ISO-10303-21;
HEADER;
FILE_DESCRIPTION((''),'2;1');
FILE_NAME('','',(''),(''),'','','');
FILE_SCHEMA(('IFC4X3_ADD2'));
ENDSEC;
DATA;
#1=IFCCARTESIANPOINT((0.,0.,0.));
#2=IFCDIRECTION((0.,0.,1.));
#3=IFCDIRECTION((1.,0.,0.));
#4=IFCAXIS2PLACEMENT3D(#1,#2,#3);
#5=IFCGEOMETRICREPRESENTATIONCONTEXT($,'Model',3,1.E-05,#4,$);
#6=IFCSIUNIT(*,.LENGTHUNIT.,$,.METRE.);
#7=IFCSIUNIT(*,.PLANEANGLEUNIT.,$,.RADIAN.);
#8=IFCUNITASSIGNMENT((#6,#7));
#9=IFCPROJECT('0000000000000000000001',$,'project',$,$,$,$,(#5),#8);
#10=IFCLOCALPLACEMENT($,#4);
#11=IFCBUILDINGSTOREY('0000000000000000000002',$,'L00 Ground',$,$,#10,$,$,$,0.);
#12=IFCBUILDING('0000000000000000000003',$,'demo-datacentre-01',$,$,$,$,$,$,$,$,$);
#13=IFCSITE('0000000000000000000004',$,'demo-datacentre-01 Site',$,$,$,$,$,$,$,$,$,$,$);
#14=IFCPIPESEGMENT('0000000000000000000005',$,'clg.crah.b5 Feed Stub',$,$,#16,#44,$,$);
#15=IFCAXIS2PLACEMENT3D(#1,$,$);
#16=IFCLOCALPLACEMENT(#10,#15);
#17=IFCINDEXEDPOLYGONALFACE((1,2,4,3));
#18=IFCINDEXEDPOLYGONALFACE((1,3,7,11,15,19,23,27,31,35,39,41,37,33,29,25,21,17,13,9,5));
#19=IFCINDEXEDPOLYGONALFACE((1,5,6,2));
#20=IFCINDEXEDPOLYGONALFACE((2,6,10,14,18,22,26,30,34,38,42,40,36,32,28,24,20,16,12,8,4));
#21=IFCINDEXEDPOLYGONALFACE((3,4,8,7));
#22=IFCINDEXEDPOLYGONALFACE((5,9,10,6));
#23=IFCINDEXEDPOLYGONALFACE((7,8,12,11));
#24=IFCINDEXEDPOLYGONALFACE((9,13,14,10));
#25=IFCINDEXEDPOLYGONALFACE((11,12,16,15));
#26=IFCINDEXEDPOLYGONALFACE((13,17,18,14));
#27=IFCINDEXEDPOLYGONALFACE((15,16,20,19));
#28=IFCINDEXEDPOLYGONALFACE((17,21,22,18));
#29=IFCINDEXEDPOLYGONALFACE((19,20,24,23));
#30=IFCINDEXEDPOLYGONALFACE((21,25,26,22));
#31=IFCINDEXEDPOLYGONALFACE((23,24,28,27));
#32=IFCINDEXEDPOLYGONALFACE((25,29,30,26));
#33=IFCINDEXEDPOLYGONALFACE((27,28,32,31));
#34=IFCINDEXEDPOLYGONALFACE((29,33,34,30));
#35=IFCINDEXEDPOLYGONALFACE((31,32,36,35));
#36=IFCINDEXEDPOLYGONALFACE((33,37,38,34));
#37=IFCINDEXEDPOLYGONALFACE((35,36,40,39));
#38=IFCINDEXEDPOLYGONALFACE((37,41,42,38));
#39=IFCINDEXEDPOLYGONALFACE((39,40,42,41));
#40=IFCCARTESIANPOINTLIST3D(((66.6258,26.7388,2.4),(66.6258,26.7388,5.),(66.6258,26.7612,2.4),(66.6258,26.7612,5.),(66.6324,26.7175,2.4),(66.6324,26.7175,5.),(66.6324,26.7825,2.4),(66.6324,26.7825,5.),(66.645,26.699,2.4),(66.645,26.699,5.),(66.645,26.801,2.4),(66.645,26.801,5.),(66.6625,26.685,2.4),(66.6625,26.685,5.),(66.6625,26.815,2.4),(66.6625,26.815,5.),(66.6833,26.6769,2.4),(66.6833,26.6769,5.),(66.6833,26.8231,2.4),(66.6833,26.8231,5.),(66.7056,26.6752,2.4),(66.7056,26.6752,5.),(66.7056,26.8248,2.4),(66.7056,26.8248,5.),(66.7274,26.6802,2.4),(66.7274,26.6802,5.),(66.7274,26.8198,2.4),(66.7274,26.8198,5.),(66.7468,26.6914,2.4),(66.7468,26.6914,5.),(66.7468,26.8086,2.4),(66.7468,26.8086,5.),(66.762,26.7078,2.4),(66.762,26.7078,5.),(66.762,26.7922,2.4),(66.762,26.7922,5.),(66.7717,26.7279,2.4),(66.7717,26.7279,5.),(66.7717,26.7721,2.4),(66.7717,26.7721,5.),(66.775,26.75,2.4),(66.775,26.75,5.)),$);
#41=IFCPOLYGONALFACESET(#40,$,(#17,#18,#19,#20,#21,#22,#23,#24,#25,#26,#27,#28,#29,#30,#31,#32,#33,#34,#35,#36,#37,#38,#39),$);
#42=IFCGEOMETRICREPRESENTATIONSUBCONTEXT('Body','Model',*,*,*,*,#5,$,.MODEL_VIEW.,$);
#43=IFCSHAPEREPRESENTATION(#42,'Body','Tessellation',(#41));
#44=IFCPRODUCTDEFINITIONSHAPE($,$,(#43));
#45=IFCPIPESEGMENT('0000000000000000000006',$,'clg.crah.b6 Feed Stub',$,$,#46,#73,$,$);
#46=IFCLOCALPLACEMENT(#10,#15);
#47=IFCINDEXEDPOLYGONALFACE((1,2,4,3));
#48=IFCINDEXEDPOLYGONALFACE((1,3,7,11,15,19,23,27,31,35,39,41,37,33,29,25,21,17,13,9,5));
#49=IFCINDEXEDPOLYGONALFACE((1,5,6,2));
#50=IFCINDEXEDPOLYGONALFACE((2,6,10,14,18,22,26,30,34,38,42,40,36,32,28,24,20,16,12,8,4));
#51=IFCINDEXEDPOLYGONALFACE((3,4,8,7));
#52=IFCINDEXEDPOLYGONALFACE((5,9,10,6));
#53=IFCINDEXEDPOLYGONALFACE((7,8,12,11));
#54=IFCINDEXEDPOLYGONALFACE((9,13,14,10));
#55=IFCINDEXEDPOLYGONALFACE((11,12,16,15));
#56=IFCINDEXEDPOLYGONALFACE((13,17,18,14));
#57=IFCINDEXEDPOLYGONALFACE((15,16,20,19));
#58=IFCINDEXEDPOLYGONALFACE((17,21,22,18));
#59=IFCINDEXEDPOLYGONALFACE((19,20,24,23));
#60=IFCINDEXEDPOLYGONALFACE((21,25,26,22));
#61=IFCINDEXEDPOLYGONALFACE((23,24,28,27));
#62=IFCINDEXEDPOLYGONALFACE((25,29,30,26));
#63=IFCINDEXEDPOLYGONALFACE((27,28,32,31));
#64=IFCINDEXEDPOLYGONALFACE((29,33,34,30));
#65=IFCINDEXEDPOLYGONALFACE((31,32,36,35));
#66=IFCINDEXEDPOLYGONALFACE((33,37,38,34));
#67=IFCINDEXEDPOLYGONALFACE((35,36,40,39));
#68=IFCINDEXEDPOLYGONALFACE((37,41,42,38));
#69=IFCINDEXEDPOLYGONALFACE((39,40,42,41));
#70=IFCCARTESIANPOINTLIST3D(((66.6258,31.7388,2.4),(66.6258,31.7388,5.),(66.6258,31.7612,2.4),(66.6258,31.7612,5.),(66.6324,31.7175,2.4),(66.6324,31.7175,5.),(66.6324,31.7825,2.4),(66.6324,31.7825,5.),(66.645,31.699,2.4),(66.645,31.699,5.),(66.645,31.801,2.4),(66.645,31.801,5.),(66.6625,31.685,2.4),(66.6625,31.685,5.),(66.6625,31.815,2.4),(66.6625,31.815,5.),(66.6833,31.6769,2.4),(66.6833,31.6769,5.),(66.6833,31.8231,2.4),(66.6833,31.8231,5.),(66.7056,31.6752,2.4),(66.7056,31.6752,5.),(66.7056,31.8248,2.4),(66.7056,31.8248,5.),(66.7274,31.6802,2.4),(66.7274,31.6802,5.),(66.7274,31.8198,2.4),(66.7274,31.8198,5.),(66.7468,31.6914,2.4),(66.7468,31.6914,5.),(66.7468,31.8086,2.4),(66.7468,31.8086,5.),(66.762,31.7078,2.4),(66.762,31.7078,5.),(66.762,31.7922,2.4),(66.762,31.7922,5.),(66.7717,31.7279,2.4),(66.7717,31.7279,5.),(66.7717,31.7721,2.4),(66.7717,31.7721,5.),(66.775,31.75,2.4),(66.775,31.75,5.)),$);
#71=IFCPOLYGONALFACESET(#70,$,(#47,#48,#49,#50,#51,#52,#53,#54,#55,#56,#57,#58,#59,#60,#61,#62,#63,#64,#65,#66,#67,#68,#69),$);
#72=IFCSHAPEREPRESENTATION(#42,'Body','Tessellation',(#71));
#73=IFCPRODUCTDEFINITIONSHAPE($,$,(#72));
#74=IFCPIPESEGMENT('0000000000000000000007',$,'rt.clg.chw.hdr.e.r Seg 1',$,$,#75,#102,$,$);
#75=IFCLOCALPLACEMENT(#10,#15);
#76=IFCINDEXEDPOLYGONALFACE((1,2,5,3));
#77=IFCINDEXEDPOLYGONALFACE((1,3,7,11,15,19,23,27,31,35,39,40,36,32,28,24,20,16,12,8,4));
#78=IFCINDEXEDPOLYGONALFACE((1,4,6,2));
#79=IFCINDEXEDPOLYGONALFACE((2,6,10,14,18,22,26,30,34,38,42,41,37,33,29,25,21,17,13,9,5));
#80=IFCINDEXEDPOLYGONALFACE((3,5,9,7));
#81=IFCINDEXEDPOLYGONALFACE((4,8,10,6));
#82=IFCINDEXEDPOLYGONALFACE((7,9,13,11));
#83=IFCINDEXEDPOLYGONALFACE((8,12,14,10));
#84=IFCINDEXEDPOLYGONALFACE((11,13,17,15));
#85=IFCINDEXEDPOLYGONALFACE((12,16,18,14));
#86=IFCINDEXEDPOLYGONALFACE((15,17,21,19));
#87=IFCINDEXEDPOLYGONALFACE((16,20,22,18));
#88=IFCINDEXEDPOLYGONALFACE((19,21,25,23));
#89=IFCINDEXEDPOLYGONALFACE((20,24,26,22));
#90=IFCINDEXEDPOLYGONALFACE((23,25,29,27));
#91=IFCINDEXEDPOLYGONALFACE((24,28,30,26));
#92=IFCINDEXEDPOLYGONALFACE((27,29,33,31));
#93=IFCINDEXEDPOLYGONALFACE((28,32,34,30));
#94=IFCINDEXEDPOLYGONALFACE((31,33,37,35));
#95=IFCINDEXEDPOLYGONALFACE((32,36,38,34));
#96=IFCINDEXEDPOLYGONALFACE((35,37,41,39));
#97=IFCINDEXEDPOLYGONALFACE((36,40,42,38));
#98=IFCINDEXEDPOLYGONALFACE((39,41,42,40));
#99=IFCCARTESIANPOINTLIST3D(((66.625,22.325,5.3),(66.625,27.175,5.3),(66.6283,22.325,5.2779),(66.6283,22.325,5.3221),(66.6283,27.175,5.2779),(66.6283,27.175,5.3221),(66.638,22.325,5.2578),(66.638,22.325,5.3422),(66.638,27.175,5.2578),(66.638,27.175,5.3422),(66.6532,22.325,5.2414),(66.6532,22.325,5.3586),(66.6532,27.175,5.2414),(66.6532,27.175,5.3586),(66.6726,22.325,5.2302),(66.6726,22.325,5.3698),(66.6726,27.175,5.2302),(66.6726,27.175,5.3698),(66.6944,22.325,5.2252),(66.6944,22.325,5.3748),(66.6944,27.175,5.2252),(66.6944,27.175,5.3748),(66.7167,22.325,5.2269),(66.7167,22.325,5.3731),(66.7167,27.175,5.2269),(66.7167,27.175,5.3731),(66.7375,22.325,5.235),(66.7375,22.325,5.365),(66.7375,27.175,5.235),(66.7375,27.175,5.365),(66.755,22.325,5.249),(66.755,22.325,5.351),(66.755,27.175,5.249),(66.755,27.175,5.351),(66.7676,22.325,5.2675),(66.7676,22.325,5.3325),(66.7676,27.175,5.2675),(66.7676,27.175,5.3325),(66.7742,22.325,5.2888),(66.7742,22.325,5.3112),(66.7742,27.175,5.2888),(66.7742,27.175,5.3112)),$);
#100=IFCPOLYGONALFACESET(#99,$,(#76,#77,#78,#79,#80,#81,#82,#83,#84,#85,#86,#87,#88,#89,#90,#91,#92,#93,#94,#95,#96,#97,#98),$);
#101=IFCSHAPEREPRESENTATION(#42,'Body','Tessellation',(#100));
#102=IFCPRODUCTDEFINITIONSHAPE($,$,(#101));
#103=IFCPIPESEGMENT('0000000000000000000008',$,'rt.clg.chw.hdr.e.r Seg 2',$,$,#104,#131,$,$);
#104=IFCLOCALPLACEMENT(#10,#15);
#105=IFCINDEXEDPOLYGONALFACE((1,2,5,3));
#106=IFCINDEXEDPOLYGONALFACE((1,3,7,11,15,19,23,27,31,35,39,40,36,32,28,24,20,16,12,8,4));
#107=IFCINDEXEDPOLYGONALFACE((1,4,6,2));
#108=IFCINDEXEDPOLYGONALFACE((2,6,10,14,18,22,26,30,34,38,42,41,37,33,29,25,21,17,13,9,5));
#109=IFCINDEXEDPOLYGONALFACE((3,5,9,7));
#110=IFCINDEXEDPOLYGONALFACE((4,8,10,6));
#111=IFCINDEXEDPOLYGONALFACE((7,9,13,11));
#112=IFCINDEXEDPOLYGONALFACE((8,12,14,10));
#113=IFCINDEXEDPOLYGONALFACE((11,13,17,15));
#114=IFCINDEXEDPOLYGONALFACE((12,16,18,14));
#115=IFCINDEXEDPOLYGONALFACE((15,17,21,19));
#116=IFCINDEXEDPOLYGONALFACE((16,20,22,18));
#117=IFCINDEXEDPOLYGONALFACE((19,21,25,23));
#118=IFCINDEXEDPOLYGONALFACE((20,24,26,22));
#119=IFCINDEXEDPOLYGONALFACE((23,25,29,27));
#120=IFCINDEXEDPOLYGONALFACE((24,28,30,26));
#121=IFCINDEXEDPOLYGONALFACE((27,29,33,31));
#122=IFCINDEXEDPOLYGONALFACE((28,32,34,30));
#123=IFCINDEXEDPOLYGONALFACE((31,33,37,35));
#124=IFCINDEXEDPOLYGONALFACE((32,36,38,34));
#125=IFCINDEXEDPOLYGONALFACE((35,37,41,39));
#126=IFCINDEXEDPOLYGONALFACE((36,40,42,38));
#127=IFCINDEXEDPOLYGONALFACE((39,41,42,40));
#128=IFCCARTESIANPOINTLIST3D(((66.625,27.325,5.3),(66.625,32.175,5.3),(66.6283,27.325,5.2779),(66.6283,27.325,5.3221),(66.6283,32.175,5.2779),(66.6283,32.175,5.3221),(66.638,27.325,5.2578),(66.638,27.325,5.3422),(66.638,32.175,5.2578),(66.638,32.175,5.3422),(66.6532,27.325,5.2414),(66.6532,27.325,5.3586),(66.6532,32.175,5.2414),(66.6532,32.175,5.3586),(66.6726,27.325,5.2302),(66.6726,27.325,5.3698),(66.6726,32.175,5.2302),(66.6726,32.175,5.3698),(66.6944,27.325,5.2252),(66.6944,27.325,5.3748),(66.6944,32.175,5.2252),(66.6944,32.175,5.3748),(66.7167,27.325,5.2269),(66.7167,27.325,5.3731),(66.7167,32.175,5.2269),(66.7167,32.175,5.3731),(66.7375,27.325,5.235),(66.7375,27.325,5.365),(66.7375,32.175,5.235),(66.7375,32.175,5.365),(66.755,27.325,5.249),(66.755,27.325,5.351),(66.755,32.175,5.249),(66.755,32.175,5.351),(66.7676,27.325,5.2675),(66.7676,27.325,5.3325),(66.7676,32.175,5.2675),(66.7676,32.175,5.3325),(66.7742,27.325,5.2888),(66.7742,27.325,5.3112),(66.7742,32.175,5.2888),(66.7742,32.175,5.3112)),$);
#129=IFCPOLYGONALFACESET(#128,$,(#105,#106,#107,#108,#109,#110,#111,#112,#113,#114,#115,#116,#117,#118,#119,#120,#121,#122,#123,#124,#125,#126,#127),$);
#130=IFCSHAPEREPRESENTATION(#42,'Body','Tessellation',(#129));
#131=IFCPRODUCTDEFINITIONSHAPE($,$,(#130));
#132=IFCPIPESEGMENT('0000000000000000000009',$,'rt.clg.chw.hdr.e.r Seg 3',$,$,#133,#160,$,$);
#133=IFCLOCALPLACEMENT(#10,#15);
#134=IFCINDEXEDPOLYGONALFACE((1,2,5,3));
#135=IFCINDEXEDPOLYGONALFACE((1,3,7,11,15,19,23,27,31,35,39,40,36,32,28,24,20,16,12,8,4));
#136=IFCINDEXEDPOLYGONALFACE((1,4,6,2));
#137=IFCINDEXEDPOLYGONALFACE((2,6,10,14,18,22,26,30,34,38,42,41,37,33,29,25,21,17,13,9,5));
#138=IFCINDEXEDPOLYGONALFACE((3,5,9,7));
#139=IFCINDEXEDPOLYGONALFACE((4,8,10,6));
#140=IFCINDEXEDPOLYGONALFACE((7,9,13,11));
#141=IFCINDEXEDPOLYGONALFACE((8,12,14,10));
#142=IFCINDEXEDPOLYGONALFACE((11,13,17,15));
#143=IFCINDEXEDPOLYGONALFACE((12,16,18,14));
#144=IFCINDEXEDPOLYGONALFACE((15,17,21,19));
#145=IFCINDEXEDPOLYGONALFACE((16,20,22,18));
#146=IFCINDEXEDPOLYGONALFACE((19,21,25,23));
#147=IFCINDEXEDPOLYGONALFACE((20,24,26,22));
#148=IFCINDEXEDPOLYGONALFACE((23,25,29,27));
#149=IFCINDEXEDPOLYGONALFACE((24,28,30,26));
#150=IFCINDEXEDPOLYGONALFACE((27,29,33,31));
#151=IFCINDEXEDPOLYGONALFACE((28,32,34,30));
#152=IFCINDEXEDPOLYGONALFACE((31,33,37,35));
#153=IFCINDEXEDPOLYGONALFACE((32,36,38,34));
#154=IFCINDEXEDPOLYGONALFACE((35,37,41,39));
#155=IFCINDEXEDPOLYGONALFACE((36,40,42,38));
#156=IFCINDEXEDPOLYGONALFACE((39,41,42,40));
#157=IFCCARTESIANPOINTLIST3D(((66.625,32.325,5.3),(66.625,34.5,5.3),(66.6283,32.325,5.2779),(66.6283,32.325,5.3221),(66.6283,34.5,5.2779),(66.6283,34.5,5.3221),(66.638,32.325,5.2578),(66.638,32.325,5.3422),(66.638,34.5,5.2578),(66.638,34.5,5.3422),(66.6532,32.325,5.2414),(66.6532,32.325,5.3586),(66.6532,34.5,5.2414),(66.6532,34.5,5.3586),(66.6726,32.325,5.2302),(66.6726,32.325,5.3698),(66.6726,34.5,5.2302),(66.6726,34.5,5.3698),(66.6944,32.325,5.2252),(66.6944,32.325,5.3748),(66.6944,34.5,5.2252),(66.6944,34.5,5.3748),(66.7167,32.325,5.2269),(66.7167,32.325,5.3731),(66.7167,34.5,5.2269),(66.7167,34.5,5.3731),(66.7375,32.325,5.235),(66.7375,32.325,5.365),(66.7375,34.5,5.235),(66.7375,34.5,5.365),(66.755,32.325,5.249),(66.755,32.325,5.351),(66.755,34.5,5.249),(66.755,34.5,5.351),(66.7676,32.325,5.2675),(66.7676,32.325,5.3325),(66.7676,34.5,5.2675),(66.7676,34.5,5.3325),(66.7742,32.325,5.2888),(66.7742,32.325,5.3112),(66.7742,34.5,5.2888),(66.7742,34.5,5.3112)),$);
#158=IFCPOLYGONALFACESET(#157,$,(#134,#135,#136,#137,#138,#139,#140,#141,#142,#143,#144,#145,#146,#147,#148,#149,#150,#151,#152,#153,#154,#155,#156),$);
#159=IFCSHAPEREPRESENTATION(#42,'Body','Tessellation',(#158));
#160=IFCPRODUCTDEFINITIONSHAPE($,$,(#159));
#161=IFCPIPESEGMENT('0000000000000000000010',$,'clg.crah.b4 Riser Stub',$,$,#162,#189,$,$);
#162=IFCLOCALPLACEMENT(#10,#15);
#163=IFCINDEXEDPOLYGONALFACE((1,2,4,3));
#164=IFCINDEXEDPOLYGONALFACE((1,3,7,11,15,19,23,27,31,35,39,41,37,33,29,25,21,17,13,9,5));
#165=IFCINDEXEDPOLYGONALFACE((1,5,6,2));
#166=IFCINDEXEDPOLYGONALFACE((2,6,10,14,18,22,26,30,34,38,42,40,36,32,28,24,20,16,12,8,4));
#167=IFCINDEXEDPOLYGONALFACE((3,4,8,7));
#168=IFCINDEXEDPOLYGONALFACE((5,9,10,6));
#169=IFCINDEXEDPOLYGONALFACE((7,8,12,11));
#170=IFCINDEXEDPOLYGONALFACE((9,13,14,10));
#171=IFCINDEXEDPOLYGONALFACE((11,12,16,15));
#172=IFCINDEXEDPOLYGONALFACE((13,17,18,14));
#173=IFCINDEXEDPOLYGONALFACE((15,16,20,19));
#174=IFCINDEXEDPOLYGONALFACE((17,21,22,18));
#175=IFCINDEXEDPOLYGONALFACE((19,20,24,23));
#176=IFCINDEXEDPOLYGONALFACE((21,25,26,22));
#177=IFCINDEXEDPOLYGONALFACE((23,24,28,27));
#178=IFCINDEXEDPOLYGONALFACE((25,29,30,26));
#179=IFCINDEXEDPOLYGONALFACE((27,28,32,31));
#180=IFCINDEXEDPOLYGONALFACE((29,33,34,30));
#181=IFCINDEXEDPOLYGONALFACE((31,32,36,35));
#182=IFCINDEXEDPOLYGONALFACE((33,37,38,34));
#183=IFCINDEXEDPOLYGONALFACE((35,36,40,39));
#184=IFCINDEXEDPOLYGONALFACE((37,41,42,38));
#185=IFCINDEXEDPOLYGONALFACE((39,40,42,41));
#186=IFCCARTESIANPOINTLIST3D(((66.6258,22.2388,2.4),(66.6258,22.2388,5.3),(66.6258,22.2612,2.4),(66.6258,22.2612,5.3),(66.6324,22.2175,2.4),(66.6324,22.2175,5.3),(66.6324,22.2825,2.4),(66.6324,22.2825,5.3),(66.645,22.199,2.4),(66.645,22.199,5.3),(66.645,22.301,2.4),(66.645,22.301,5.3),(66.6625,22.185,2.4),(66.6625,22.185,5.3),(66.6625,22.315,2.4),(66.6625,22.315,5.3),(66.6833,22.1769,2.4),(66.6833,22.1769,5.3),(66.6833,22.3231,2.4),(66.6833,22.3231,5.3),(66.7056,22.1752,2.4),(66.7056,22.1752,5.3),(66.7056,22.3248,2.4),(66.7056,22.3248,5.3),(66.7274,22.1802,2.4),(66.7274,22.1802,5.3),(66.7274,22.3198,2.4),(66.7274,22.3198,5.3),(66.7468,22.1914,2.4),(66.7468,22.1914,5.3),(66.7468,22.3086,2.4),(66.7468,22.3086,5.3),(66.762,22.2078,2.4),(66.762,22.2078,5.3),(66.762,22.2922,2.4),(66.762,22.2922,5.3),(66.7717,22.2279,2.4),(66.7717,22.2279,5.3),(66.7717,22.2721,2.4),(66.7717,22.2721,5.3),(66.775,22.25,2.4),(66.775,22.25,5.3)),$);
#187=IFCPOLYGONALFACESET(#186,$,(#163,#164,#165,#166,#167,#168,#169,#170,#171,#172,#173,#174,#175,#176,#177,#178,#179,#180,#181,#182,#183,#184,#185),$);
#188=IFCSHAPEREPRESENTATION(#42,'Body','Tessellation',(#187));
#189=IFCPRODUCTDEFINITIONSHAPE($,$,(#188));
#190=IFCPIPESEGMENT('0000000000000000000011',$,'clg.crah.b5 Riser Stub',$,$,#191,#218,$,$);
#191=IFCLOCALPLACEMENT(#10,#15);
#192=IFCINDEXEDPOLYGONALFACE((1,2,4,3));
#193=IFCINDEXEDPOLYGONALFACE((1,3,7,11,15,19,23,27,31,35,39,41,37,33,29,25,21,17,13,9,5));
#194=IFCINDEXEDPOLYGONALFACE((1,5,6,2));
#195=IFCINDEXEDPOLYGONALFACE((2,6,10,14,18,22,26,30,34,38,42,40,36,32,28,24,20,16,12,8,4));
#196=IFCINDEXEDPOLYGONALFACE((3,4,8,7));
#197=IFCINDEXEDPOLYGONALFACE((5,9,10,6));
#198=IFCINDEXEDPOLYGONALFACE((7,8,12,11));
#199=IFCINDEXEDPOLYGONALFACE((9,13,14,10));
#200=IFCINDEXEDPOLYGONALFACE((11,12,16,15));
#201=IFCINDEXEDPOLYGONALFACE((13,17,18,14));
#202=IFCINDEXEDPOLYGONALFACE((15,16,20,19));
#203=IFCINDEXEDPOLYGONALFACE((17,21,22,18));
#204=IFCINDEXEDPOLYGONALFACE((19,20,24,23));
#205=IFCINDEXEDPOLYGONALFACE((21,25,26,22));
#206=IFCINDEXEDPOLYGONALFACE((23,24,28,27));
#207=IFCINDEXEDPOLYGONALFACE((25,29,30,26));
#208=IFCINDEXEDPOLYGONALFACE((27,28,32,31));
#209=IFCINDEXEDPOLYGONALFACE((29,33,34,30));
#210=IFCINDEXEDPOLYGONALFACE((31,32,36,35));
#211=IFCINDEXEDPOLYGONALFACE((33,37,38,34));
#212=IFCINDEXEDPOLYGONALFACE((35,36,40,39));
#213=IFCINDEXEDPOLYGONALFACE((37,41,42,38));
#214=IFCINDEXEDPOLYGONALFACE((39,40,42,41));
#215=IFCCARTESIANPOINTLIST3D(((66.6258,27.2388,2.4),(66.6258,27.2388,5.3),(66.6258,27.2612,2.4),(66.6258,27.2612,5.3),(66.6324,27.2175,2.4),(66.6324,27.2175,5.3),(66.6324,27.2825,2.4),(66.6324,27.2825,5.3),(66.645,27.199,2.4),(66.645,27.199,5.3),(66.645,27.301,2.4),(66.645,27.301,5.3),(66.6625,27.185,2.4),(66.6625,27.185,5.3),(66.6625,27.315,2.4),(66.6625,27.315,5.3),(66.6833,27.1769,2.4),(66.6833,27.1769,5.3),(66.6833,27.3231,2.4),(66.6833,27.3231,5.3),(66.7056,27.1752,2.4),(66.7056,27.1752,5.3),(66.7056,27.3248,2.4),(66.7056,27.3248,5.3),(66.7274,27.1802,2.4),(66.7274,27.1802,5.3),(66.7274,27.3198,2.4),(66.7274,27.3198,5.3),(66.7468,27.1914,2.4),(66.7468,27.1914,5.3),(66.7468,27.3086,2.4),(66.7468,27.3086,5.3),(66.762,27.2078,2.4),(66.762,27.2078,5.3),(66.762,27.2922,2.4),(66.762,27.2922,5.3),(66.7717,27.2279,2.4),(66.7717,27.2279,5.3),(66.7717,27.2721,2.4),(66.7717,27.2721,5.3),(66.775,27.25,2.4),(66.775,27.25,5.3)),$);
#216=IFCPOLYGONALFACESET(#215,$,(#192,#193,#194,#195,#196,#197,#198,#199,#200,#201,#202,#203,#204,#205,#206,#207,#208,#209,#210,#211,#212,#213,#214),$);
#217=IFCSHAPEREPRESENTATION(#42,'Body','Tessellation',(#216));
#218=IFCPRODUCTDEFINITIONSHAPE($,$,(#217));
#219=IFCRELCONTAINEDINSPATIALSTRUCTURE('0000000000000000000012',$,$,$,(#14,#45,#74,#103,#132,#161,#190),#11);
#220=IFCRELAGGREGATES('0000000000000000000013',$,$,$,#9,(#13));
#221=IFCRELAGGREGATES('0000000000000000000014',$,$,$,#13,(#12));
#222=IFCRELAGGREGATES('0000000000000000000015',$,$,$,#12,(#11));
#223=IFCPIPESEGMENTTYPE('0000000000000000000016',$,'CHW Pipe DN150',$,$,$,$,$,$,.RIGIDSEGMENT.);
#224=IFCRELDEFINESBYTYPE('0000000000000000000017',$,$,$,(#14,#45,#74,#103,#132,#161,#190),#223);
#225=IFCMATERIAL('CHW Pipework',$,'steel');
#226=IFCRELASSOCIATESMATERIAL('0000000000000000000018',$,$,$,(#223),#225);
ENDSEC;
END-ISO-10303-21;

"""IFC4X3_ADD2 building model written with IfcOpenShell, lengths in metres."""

from ifc_helpers import new_model, si_unit, frame, origin_with_axes, place, context, subcontext, project, spatial, circle, extrude, material, type_object, element, save


model = new_model("IFC4X3_ADD2")

# Units and contexts
model_context = context("Model", 3, precision=1e-05, world=origin_with_axes())
body_context = subcontext(model_context, "Body", "Model", "MODEL_VIEW")
ifc_project = project(units=[si_unit("LENGTHUNIT", "METRE"), si_unit("PLANEANGLEUNIT", "RADIAN")], contexts=[model_context])

# Site, building, storey
site = spatial("IfcSite", under=ifc_project, Name="demo-datacentre-01 Site")
building = spatial("IfcBuilding", under=site, Name="demo-datacentre-01")
storey_placement = place(None, origin_with_axes())
storey = spatial("IfcBuildingStorey", under=building, at=storey_placement, Name="L00 Ground", Elevation=0.0)

# Shared definitions
ifc_material = material(Name="CHW Pipework", Category="steel")

# Pipe segments
pipe_segment_type_1 = type_object("IfcPipeSegmentType", Name="CHW Pipe DN150", PredefinedType="RIGIDSEGMENT", material=ifc_material)
for number, where, z_axis, x_axis, name in (
    (1, (66.7, 26.75, 5.0), (0.0, 0.0, -1.0), (1.0, 0.0, 0.0), "clg.crah.b5 Feed Stub"),
    (2, (66.7, 31.75, 5.0), (0.0, 0.0, -1.0), (1.0, 0.0, 0.0), "clg.crah.b6 Feed Stub"),
):
    element("IfcPipeSegment", number, at=place(storey_placement, frame(where, z_axis=z_axis, x_axis=x_axis)), inside=storey, type_object=pipe_segment_type_1, Name=name, context=body_context, shape_type="SweptSolid", body=[
        extrude(circle(Radius=0.075), origin_with_axes(), (0.0, 0.0, 1.0), 2.6),
    ])
pipe_segment_1_placement = place(storey_placement, frame((66.7, 22.325, 5.3), z_axis=(0.0, 1.0, 0.0), x_axis=(-1.0, 0.0, 0.0)))
element("IfcPipeSegment", 3, at=pipe_segment_1_placement, inside=storey, type_object=pipe_segment_type_1, Name="rt.clg.chw.hdr.e.r Seg 1", context=body_context, shape_type="SweptSolid", body=[
    extrude(circle(Radius=0.075), origin_with_axes(), (0.0, 0.0, 1.0), 4.85),
])
pipe_segment_2_placement = place(storey_placement, frame((66.7, 27.325, 5.3), z_axis=(0.0, 1.0, 0.0), x_axis=(-1.0, 0.0, 0.0)))
element("IfcPipeSegment", 4, at=pipe_segment_2_placement, inside=storey, type_object=pipe_segment_type_1, Name="rt.clg.chw.hdr.e.r Seg 2", context=body_context, shape_type="SweptSolid", body=[
    extrude(circle(Radius=0.075), origin_with_axes(), (0.0, 0.0, 1.0), 4.85),
])
pipe_segment_3_placement = place(storey_placement, frame((66.7, 32.325, 5.3), z_axis=(0.0, 1.0, 0.0), x_axis=(-1.0, 0.0, 0.0)))
element("IfcPipeSegment", 5, at=pipe_segment_3_placement, inside=storey, type_object=pipe_segment_type_1, Name="rt.clg.chw.hdr.e.r Seg 3", context=body_context, shape_type="SweptSolid", body=[
    extrude(circle(Radius=0.075), origin_with_axes(), (0.0, 0.0, 1.0), 2.175),
])
for number, where, z_axis, x_axis, name in (
    (6, (66.7, 22.25, 5.3), (0.0, 0.0, -1.0), (1.0, 0.0, 0.0), "clg.crah.b4 Riser Stub"),
    (7, (66.7, 27.25, 5.3), (0.0, 0.0, -1.0), (1.0, 0.0, 0.0), "clg.crah.b5 Riser Stub"),
):
    element("IfcPipeSegment", number, at=place(storey_placement, frame(where, z_axis=z_axis, x_axis=x_axis)), inside=storey, type_object=pipe_segment_type_1, Name=name, context=body_context, shape_type="SweptSolid", body=[
        extrude(circle(Radius=0.075), origin_with_axes(), (0.0, 0.0, 1.0), 2.9),
    ])

save(model, "model.ifc")
